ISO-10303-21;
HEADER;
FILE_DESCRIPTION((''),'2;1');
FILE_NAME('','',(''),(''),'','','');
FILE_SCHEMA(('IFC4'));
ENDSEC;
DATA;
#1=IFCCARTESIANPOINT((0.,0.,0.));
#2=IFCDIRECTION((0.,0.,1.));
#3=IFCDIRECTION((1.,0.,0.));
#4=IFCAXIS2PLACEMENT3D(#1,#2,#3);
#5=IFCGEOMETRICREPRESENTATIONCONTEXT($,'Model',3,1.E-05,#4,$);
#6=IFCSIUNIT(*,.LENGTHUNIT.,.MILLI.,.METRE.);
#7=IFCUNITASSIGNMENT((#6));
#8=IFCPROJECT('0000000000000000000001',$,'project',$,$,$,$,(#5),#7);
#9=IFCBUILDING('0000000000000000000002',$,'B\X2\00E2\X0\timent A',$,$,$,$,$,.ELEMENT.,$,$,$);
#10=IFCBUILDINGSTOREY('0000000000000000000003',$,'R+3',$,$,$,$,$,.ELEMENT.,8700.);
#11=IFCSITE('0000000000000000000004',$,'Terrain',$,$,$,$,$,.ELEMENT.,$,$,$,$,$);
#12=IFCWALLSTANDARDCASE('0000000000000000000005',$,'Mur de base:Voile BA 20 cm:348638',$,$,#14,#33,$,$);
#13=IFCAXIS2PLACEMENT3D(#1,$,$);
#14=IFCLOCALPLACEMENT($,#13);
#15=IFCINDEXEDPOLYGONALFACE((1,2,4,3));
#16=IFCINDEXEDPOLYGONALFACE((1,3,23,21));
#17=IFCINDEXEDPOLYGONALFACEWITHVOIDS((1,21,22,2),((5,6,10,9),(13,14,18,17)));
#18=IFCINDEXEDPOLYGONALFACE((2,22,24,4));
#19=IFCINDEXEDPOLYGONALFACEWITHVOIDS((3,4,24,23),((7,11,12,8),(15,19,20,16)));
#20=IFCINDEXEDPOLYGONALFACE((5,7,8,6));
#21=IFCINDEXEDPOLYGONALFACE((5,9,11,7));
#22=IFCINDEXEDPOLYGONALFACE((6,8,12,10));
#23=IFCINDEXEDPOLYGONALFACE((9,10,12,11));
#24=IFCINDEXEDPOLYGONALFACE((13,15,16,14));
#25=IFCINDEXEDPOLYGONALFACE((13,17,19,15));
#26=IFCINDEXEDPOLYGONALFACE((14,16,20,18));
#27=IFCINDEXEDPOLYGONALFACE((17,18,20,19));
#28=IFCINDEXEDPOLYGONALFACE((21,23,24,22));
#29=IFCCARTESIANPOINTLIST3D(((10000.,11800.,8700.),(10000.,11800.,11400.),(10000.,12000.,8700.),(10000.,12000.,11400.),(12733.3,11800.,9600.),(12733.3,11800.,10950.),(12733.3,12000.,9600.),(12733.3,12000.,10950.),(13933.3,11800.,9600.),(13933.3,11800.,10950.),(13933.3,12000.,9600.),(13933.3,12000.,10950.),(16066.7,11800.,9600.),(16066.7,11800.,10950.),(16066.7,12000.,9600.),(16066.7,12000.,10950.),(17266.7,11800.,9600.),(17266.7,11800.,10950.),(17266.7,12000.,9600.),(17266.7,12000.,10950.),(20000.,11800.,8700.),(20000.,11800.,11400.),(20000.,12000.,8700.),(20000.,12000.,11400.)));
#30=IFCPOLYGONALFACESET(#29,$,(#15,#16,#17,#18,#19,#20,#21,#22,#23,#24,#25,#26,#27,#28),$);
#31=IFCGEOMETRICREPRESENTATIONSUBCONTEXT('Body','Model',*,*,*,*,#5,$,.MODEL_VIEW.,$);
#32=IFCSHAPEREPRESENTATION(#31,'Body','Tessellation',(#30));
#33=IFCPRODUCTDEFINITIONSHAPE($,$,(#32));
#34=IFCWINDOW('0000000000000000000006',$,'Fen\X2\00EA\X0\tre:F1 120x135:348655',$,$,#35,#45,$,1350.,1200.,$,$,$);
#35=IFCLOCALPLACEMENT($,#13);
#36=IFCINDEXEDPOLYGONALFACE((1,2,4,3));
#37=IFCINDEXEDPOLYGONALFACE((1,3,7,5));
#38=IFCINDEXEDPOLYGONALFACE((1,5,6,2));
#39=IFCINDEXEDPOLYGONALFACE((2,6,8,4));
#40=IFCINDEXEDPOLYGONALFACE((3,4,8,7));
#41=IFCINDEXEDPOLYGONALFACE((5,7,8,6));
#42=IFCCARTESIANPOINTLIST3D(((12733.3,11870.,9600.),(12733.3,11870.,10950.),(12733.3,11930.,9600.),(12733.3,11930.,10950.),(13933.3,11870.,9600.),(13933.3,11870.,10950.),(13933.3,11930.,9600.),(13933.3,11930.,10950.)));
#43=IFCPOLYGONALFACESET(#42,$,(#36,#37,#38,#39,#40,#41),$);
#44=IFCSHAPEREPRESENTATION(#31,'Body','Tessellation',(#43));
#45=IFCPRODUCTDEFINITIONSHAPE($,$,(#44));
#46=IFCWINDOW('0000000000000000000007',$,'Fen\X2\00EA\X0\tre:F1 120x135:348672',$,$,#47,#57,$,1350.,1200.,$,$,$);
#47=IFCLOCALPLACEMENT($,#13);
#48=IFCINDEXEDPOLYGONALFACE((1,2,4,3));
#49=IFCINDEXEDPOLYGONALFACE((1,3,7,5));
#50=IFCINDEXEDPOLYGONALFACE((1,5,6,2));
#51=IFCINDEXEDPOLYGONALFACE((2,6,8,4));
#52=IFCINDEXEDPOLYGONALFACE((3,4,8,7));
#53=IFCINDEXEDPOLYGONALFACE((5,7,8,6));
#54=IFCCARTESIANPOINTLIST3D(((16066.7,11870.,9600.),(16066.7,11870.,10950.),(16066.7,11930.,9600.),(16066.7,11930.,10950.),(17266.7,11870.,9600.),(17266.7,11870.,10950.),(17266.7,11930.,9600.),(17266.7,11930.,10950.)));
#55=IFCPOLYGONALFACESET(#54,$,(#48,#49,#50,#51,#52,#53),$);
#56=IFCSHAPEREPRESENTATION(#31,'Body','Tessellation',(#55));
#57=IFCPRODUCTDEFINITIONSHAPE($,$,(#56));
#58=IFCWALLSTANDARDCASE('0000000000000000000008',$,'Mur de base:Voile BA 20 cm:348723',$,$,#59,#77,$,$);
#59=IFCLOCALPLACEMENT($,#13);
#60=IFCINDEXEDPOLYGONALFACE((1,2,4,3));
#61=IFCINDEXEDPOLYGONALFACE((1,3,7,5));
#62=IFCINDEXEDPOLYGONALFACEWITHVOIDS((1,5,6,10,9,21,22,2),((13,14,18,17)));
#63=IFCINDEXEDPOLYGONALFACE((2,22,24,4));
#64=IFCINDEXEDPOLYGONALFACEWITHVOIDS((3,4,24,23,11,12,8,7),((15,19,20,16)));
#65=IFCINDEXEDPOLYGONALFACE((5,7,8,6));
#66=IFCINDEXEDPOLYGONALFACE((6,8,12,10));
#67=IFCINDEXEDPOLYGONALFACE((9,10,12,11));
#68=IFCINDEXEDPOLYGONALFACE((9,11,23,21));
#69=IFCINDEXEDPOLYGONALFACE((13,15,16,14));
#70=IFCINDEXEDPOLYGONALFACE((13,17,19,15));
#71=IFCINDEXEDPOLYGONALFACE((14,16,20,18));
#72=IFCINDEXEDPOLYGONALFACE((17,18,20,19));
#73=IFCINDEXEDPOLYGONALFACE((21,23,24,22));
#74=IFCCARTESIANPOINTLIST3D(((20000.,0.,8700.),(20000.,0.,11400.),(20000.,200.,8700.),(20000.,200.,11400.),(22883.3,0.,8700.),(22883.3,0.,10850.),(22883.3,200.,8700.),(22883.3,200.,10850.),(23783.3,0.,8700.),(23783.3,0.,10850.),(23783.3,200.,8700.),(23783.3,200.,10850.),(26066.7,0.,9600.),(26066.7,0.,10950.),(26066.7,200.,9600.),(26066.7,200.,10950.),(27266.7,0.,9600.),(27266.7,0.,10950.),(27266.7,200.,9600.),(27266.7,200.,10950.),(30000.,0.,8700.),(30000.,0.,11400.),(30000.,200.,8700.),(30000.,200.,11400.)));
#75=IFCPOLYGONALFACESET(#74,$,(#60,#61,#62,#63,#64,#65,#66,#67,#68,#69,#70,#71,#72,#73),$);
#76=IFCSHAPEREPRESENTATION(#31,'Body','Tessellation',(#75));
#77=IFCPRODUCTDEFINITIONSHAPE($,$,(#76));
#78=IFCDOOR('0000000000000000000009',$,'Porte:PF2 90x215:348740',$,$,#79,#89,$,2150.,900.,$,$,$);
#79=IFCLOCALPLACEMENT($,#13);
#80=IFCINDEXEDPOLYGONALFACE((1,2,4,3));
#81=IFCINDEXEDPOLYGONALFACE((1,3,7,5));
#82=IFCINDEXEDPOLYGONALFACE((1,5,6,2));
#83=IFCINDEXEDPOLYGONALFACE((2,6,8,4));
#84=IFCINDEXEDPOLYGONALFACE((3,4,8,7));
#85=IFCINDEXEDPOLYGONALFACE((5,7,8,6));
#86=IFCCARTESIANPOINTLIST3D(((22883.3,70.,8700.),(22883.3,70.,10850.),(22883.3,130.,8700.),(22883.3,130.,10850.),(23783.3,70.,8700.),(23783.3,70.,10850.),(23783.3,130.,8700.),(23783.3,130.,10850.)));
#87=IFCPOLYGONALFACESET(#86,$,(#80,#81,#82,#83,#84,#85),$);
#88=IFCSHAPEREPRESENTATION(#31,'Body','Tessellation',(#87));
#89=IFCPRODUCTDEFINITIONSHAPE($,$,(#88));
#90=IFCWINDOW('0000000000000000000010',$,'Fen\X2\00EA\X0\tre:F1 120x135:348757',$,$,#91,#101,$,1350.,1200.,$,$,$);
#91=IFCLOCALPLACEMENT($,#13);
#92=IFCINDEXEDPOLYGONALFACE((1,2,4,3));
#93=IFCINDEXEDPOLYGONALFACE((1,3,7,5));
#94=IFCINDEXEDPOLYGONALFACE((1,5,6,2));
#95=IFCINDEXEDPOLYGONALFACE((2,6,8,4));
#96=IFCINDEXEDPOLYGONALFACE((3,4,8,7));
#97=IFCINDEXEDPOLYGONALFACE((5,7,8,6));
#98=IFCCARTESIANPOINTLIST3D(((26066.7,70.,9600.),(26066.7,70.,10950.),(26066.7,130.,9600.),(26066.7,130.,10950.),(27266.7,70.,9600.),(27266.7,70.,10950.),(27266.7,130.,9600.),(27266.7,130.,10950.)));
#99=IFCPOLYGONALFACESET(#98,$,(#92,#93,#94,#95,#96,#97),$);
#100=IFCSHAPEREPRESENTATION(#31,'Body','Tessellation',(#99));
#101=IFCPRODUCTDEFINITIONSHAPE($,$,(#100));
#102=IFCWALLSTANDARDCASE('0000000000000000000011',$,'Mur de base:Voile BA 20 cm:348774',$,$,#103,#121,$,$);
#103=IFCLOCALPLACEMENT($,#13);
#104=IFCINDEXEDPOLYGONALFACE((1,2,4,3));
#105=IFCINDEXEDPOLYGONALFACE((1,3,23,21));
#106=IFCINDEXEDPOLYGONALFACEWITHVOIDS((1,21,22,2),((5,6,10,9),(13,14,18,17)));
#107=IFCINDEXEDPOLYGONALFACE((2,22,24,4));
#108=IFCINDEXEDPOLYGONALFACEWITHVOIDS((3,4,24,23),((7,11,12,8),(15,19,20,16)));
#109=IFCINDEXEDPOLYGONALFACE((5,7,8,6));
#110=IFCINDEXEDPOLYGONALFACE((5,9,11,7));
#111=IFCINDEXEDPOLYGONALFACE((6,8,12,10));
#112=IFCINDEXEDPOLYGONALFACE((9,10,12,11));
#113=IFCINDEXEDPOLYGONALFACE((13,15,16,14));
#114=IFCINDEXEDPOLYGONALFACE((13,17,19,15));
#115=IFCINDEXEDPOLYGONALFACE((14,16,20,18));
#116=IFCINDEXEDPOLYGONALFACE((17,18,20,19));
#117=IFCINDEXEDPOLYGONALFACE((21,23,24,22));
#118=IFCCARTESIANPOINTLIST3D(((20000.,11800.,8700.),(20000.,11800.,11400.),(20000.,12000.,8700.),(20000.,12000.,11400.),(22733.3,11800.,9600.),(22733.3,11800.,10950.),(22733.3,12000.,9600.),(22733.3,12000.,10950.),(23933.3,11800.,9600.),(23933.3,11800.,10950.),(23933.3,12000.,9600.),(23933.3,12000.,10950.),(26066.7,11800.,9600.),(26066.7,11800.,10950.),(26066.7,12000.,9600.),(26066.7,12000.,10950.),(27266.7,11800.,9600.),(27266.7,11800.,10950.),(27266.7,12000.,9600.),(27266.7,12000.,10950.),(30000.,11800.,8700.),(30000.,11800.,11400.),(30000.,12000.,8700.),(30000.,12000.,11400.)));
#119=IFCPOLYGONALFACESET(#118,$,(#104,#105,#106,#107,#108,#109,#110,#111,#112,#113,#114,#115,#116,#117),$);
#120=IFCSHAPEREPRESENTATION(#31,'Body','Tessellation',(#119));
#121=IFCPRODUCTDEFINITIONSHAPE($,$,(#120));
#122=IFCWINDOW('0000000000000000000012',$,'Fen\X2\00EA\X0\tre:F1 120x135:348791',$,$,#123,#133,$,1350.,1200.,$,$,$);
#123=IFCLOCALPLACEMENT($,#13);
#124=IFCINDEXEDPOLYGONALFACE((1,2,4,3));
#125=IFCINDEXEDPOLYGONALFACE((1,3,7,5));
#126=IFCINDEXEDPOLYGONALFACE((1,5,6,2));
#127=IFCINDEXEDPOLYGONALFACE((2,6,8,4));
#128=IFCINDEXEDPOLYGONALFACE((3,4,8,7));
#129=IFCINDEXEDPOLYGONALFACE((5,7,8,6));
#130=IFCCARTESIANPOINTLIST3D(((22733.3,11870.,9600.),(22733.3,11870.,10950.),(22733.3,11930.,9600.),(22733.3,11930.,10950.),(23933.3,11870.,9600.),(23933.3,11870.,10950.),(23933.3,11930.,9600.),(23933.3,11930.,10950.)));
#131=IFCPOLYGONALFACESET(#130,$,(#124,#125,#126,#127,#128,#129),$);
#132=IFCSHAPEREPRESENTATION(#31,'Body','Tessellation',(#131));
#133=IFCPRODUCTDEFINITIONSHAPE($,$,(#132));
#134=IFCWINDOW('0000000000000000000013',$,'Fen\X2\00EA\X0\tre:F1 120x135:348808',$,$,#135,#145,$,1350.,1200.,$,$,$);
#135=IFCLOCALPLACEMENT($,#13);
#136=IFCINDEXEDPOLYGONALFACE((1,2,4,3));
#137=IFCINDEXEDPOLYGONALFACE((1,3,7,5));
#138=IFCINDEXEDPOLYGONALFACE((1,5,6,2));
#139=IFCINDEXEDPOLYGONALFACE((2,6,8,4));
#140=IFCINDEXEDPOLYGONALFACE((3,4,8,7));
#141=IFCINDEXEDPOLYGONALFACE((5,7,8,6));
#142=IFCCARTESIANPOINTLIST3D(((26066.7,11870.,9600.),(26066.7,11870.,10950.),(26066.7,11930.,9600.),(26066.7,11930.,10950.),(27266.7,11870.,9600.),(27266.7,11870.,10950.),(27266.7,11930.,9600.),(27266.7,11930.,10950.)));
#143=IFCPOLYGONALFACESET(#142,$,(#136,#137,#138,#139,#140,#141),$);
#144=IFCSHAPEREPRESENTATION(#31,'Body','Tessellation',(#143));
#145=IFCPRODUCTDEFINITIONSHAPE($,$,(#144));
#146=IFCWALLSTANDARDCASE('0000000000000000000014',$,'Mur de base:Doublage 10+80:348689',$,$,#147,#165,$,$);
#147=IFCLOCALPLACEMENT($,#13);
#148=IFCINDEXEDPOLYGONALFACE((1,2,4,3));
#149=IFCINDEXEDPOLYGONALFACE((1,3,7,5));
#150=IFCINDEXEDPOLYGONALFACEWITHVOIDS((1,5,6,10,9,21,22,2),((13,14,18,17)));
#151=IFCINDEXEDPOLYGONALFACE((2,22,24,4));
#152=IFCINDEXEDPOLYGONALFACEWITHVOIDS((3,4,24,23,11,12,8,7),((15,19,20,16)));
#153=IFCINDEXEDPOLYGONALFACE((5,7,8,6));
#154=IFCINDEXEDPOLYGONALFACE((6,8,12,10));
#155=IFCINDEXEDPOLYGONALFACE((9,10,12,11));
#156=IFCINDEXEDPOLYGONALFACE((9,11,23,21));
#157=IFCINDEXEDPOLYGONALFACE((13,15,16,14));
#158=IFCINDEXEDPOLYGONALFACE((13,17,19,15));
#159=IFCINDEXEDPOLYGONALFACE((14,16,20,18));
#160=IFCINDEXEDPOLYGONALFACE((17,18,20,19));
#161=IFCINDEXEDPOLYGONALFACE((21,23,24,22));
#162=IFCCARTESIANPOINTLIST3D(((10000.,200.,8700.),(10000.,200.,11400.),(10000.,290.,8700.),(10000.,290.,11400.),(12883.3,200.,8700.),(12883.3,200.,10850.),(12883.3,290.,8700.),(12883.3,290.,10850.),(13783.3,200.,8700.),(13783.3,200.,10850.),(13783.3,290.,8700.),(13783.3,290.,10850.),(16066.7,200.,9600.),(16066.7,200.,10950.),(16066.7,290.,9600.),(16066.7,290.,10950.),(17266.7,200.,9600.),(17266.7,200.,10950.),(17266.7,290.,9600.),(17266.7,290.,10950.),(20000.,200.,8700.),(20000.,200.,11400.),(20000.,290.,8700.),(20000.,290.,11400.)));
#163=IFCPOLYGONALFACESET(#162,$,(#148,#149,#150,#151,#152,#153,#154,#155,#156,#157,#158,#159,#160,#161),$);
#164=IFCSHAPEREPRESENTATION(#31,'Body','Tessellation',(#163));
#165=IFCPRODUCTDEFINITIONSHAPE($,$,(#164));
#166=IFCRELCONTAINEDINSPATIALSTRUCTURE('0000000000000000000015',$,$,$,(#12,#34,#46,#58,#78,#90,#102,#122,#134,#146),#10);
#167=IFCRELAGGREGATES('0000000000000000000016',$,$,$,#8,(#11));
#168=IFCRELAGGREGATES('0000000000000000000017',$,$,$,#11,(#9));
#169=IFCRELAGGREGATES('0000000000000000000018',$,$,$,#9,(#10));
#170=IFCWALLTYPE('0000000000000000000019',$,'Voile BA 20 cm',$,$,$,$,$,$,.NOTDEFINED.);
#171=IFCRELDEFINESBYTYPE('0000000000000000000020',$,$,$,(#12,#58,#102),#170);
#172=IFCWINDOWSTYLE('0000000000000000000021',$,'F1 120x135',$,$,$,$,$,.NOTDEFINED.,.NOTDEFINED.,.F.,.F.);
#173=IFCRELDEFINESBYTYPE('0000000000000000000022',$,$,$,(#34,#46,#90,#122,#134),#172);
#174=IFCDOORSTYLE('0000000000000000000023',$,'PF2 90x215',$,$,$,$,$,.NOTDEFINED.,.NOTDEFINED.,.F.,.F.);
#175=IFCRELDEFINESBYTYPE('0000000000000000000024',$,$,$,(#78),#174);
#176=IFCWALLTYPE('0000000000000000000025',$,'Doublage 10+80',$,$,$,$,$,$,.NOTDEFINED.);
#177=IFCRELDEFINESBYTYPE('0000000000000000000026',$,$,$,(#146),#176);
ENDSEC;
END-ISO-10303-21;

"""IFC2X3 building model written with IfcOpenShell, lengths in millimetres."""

from ifc_helpers import new_model, si_unit, frame, frame_2d, origin_with_axes, place, context, subcontext, project, spatial, rectangle, extrude, type_object, element, fill, save


model = new_model("IFC2X3")

# Units and contexts
model_context = context("Model", 3, precision=1e-05, world=origin_with_axes())
body_context = subcontext(model_context, "Body", "Model", "MODEL_VIEW")
ifc_project = project(units=[si_unit("LENGTHUNIT", "METRE", prefix="MILLI")], contexts=[model_context])

# Site, building, storey
site = spatial("IfcSite", under=ifc_project, Name="Terrain", CompositionType="ELEMENT")
building = spatial("IfcBuilding", under=site, Name="Bâtiment A", CompositionType="ELEMENT")
storey = spatial("IfcBuildingStorey", under=building, Name="R+3", CompositionType="ELEMENT", Elevation=8700.0)

# Wall, openings, windows
wall_type_1 = type_object("IfcWallType", Name="Voile BA 20 cm", PredefinedType="NOTDEFINED")
wall_1_placement = place(None, origin_with_axes())
wall_1 = element("IfcWallStandardCase", 1, at=wall_1_placement, inside=storey, type_object=wall_type_1, Name="Mur de base:Voile BA 20 cm:348638", context=body_context, shape_type="SweptSolid", body=[
    extrude(rectangle(XDim=10000.0, YDim=200.0, at=frame_2d((15000.0, 11900.0))), frame((0.0, 0.0, 8700.0), z_axis=(0.0, 0.0, 1.0), x_axis=(1.0, 0.0, 0.0)), (0.0, 0.0, 1.0), 2700.0),
])
opening_1_placement = place(None, origin_with_axes())
opening_1 = element("IfcOpeningElement", 2, at=opening_1_placement, cuts=wall_1, context=body_context, shape_type="SweptSolid", body=[
    extrude(rectangle(XDim=1200.0, YDim=320.0, at=frame_2d((13333.3, 11900.0))), frame((0.0, 0.0, 9600.0), z_axis=(0.0, 0.0, 1.0), x_axis=(1.0, 0.0, 0.0)), (0.0, 0.0, 1.0), 1350.0),
])
opening_2_placement = place(None, origin_with_axes())
opening_2 = element("IfcOpeningElement", 3, at=opening_2_placement, cuts=wall_1, context=body_context, shape_type="SweptSolid", body=[
    extrude(rectangle(XDim=1200.0, YDim=320.0, at=frame_2d((16666.7, 11900.0))), frame((0.0, 0.0, 9600.0), z_axis=(0.0, 0.0, 1.0), x_axis=(1.0, 0.0, 0.0)), (0.0, 0.0, 1.0), 1350.0),
])
window_style = type_object("IfcWindowStyle", Name="F1 120x135", ConstructionType="NOTDEFINED", OperationType="NOTDEFINED", ParameterTakesPrecedence=False, Sizeable=False)
window_1_placement = place(None, origin_with_axes())
window_1 = element("IfcWindow", 4, at=window_1_placement, inside=storey, type_object=window_style, Name="Fenêtre:F1 120x135:348655", OverallHeight=1350.0, OverallWidth=1200.0, context=body_context, shape_type="SweptSolid", body=[
    extrude(rectangle(XDim=1200.0, YDim=60.0, at=frame_2d((13333.3, 11900.0))), frame((0.0, 0.0, 9600.0), z_axis=(0.0, 0.0, 1.0), x_axis=(1.0, 0.0, 0.0)), (0.0, 0.0, 1.0), 1350.0),
])
fill(opening_1, window_1)
window_2_placement = place(None, origin_with_axes())
window_2 = element("IfcWindow", 5, at=window_2_placement, inside=storey, type_object=window_style, Name="Fenêtre:F1 120x135:348672", OverallHeight=1350.0, OverallWidth=1200.0, context=body_context, shape_type="SweptSolid", body=[
    extrude(rectangle(XDim=1200.0, YDim=60.0, at=frame_2d((16666.7, 11900.0))), frame((0.0, 0.0, 9600.0), z_axis=(0.0, 0.0, 1.0), x_axis=(1.0, 0.0, 0.0)), (0.0, 0.0, 1.0), 1350.0),
])
fill(opening_2, window_2)

# Wall, openings, door, window
wall_2_placement = place(None, origin_with_axes())
wall_2 = element("IfcWallStandardCase", 6, at=wall_2_placement, inside=storey, type_object=wall_type_1, Name="Mur de base:Voile BA 20 cm:348723", context=body_context, shape_type="SweptSolid", body=[
    extrude(rectangle(XDim=10000.0, YDim=200.0, at=frame_2d((25000.0, 100.0))), frame((0.0, 0.0, 8700.0), z_axis=(0.0, 0.0, 1.0), x_axis=(1.0, 0.0, 0.0)), (0.0, 0.0, 1.0), 2700.0),
])
opening_3_placement = place(None, origin_with_axes())
opening_3 = element("IfcOpeningElement", 7, at=opening_3_placement, cuts=wall_2, context=body_context, shape_type="SweptSolid", body=[
    extrude(rectangle(XDim=900.0, YDim=320.0, at=frame_2d((23333.3, 100.0))), frame((0.0, 0.0, 8700.0), z_axis=(0.0, 0.0, 1.0), x_axis=(1.0, 0.0, 0.0)), (0.0, 0.0, 1.0), 2150.0),
])
opening_4_placement = place(None, origin_with_axes())
opening_4 = element("IfcOpeningElement", 8, at=opening_4_placement, cuts=wall_2, context=body_context, shape_type="SweptSolid", body=[
    extrude(rectangle(XDim=1200.0, YDim=320.0, at=frame_2d((26666.7, 100.0))), frame((0.0, 0.0, 9600.0), z_axis=(0.0, 0.0, 1.0), x_axis=(1.0, 0.0, 0.0)), (0.0, 0.0, 1.0), 1350.0),
])
door_style = type_object("IfcDoorStyle", Name="PF2 90x215", ConstructionType="NOTDEFINED", OperationType="NOTDEFINED", ParameterTakesPrecedence=False, Sizeable=False)
door_placement = place(None, origin_with_axes())
door = element("IfcDoor", 9, at=door_placement, inside=storey, type_object=door_style, Name="Porte:PF2 90x215:348740", OverallHeight=2150.0, OverallWidth=900.0, context=body_context, shape_type="SweptSolid", body=[
    extrude(rectangle(XDim=900.0, YDim=60.0, at=frame_2d((23333.3, 100.0))), frame((0.0, 0.0, 8700.0), z_axis=(0.0, 0.0, 1.0), x_axis=(1.0, 0.0, 0.0)), (0.0, 0.0, 1.0), 2150.0),
])
fill(opening_3, door)
window_3_placement = place(None, origin_with_axes())
window_3 = element("IfcWindow", 10, at=window_3_placement, inside=storey, type_object=window_style, Name="Fenêtre:F1 120x135:348757", OverallHeight=1350.0, OverallWidth=1200.0, context=body_context, shape_type="SweptSolid", body=[
    extrude(rectangle(XDim=1200.0, YDim=60.0, at=frame_2d((26666.7, 100.0))), frame((0.0, 0.0, 9600.0), z_axis=(0.0, 0.0, 1.0), x_axis=(1.0, 0.0, 0.0)), (0.0, 0.0, 1.0), 1350.0),
])
fill(opening_4, window_3)

# Wall, openings, windows
wall_3_placement = place(None, origin_with_axes())
wall_3 = element("IfcWallStandardCase", 11, at=wall_3_placement, inside=storey, type_object=wall_type_1, Name="Mur de base:Voile BA 20 cm:348774", context=body_context, shape_type="SweptSolid", body=[
    extrude(rectangle(XDim=10000.0, YDim=200.0, at=frame_2d((25000.0, 11900.0))), frame((0.0, 0.0, 8700.0), z_axis=(0.0, 0.0, 1.0), x_axis=(1.0, 0.0, 0.0)), (0.0, 0.0, 1.0), 2700.0),
])
opening_5_placement = place(None, origin_with_axes())
opening_5 = element("IfcOpeningElement", 12, at=opening_5_placement, cuts=wall_3, context=body_context, shape_type="SweptSolid", body=[
    extrude(rectangle(XDim=1200.0, YDim=320.0, at=frame_2d((23333.3, 11900.0))), frame((0.0, 0.0, 9600.0), z_axis=(0.0, 0.0, 1.0), x_axis=(1.0, 0.0, 0.0)), (0.0, 0.0, 1.0), 1350.0),
])
opening_6_placement = place(None, origin_with_axes())
opening_6 = element("IfcOpeningElement", 13, at=opening_6_placement, cuts=wall_3, context=body_context, shape_type="SweptSolid", body=[
    extrude(rectangle(XDim=1200.0, YDim=320.0, at=frame_2d((26666.7, 11900.0))), frame((0.0, 0.0, 9600.0), z_axis=(0.0, 0.0, 1.0), x_axis=(1.0, 0.0, 0.0)), (0.0, 0.0, 1.0), 1350.0),
])
window_4_placement = place(None, origin_with_axes())
window_4 = element("IfcWindow", 14, at=window_4_placement, inside=storey, type_object=window_style, Name="Fenêtre:F1 120x135:348791", OverallHeight=1350.0, OverallWidth=1200.0, context=body_context, shape_type="SweptSolid", body=[
    extrude(rectangle(XDim=1200.0, YDim=60.0, at=frame_2d((23333.3, 11900.0))), frame((0.0, 0.0, 9600.0), z_axis=(0.0, 0.0, 1.0), x_axis=(1.0, 0.0, 0.0)), (0.0, 0.0, 1.0), 1350.0),
])
fill(opening_5, window_4)
window_5_placement = place(None, origin_with_axes())
window_5 = element("IfcWindow", 15, at=window_5_placement, inside=storey, type_object=window_style, Name="Fenêtre:F1 120x135:348808", OverallHeight=1350.0, OverallWidth=1200.0, context=body_context, shape_type="SweptSolid", body=[
    extrude(rectangle(XDim=1200.0, YDim=60.0, at=frame_2d((26666.7, 11900.0))), frame((0.0, 0.0, 9600.0), z_axis=(0.0, 0.0, 1.0), x_axis=(1.0, 0.0, 0.0)), (0.0, 0.0, 1.0), 1350.0),
])
fill(opening_6, window_5)

# Wall, openings
wall_type_2 = type_object("IfcWallType", Name="Doublage 10+80", PredefinedType="NOTDEFINED")
wall_4_placement = place(None, origin_with_axes())
wall_4 = element("IfcWallStandardCase", 16, at=wall_4_placement, inside=storey, type_object=wall_type_2, Name="Mur de base:Doublage 10+80:348689", context=body_context, shape_type="SweptSolid", body=[
    extrude(rectangle(XDim=10000.0, YDim=90.0, at=frame_2d((15000.0, 245.0))), frame((0.0, 0.0, 8700.0), z_axis=(0.0, 0.0, 1.0), x_axis=(1.0, 0.0, 0.0)), (0.0, 0.0, 1.0), 2700.0),
])
opening_7_placement = place(None, origin_with_axes())
element("IfcOpeningElement", 17, at=opening_7_placement, cuts=wall_4, context=body_context, shape_type="SweptSolid", body=[
    extrude(rectangle(XDim=900.0, YDim=210.0, at=frame_2d((13333.3, 245.0))), frame((0.0, 0.0, 8700.0), z_axis=(0.0, 0.0, 1.0), x_axis=(1.0, 0.0, 0.0)), (0.0, 0.0, 1.0), 2150.0),
])
opening_8_placement = place(None, origin_with_axes())
element("IfcOpeningElement", 18, at=opening_8_placement, cuts=wall_4, context=body_context, shape_type="SweptSolid", body=[
    extrude(rectangle(XDim=1200.0, YDim=210.0, at=frame_2d((16666.7, 245.0))), frame((0.0, 0.0, 9600.0), z_axis=(0.0, 0.0, 1.0), x_axis=(1.0, 0.0, 0.0)), (0.0, 0.0, 1.0), 1350.0),
])

save(model, "model.ifc")
